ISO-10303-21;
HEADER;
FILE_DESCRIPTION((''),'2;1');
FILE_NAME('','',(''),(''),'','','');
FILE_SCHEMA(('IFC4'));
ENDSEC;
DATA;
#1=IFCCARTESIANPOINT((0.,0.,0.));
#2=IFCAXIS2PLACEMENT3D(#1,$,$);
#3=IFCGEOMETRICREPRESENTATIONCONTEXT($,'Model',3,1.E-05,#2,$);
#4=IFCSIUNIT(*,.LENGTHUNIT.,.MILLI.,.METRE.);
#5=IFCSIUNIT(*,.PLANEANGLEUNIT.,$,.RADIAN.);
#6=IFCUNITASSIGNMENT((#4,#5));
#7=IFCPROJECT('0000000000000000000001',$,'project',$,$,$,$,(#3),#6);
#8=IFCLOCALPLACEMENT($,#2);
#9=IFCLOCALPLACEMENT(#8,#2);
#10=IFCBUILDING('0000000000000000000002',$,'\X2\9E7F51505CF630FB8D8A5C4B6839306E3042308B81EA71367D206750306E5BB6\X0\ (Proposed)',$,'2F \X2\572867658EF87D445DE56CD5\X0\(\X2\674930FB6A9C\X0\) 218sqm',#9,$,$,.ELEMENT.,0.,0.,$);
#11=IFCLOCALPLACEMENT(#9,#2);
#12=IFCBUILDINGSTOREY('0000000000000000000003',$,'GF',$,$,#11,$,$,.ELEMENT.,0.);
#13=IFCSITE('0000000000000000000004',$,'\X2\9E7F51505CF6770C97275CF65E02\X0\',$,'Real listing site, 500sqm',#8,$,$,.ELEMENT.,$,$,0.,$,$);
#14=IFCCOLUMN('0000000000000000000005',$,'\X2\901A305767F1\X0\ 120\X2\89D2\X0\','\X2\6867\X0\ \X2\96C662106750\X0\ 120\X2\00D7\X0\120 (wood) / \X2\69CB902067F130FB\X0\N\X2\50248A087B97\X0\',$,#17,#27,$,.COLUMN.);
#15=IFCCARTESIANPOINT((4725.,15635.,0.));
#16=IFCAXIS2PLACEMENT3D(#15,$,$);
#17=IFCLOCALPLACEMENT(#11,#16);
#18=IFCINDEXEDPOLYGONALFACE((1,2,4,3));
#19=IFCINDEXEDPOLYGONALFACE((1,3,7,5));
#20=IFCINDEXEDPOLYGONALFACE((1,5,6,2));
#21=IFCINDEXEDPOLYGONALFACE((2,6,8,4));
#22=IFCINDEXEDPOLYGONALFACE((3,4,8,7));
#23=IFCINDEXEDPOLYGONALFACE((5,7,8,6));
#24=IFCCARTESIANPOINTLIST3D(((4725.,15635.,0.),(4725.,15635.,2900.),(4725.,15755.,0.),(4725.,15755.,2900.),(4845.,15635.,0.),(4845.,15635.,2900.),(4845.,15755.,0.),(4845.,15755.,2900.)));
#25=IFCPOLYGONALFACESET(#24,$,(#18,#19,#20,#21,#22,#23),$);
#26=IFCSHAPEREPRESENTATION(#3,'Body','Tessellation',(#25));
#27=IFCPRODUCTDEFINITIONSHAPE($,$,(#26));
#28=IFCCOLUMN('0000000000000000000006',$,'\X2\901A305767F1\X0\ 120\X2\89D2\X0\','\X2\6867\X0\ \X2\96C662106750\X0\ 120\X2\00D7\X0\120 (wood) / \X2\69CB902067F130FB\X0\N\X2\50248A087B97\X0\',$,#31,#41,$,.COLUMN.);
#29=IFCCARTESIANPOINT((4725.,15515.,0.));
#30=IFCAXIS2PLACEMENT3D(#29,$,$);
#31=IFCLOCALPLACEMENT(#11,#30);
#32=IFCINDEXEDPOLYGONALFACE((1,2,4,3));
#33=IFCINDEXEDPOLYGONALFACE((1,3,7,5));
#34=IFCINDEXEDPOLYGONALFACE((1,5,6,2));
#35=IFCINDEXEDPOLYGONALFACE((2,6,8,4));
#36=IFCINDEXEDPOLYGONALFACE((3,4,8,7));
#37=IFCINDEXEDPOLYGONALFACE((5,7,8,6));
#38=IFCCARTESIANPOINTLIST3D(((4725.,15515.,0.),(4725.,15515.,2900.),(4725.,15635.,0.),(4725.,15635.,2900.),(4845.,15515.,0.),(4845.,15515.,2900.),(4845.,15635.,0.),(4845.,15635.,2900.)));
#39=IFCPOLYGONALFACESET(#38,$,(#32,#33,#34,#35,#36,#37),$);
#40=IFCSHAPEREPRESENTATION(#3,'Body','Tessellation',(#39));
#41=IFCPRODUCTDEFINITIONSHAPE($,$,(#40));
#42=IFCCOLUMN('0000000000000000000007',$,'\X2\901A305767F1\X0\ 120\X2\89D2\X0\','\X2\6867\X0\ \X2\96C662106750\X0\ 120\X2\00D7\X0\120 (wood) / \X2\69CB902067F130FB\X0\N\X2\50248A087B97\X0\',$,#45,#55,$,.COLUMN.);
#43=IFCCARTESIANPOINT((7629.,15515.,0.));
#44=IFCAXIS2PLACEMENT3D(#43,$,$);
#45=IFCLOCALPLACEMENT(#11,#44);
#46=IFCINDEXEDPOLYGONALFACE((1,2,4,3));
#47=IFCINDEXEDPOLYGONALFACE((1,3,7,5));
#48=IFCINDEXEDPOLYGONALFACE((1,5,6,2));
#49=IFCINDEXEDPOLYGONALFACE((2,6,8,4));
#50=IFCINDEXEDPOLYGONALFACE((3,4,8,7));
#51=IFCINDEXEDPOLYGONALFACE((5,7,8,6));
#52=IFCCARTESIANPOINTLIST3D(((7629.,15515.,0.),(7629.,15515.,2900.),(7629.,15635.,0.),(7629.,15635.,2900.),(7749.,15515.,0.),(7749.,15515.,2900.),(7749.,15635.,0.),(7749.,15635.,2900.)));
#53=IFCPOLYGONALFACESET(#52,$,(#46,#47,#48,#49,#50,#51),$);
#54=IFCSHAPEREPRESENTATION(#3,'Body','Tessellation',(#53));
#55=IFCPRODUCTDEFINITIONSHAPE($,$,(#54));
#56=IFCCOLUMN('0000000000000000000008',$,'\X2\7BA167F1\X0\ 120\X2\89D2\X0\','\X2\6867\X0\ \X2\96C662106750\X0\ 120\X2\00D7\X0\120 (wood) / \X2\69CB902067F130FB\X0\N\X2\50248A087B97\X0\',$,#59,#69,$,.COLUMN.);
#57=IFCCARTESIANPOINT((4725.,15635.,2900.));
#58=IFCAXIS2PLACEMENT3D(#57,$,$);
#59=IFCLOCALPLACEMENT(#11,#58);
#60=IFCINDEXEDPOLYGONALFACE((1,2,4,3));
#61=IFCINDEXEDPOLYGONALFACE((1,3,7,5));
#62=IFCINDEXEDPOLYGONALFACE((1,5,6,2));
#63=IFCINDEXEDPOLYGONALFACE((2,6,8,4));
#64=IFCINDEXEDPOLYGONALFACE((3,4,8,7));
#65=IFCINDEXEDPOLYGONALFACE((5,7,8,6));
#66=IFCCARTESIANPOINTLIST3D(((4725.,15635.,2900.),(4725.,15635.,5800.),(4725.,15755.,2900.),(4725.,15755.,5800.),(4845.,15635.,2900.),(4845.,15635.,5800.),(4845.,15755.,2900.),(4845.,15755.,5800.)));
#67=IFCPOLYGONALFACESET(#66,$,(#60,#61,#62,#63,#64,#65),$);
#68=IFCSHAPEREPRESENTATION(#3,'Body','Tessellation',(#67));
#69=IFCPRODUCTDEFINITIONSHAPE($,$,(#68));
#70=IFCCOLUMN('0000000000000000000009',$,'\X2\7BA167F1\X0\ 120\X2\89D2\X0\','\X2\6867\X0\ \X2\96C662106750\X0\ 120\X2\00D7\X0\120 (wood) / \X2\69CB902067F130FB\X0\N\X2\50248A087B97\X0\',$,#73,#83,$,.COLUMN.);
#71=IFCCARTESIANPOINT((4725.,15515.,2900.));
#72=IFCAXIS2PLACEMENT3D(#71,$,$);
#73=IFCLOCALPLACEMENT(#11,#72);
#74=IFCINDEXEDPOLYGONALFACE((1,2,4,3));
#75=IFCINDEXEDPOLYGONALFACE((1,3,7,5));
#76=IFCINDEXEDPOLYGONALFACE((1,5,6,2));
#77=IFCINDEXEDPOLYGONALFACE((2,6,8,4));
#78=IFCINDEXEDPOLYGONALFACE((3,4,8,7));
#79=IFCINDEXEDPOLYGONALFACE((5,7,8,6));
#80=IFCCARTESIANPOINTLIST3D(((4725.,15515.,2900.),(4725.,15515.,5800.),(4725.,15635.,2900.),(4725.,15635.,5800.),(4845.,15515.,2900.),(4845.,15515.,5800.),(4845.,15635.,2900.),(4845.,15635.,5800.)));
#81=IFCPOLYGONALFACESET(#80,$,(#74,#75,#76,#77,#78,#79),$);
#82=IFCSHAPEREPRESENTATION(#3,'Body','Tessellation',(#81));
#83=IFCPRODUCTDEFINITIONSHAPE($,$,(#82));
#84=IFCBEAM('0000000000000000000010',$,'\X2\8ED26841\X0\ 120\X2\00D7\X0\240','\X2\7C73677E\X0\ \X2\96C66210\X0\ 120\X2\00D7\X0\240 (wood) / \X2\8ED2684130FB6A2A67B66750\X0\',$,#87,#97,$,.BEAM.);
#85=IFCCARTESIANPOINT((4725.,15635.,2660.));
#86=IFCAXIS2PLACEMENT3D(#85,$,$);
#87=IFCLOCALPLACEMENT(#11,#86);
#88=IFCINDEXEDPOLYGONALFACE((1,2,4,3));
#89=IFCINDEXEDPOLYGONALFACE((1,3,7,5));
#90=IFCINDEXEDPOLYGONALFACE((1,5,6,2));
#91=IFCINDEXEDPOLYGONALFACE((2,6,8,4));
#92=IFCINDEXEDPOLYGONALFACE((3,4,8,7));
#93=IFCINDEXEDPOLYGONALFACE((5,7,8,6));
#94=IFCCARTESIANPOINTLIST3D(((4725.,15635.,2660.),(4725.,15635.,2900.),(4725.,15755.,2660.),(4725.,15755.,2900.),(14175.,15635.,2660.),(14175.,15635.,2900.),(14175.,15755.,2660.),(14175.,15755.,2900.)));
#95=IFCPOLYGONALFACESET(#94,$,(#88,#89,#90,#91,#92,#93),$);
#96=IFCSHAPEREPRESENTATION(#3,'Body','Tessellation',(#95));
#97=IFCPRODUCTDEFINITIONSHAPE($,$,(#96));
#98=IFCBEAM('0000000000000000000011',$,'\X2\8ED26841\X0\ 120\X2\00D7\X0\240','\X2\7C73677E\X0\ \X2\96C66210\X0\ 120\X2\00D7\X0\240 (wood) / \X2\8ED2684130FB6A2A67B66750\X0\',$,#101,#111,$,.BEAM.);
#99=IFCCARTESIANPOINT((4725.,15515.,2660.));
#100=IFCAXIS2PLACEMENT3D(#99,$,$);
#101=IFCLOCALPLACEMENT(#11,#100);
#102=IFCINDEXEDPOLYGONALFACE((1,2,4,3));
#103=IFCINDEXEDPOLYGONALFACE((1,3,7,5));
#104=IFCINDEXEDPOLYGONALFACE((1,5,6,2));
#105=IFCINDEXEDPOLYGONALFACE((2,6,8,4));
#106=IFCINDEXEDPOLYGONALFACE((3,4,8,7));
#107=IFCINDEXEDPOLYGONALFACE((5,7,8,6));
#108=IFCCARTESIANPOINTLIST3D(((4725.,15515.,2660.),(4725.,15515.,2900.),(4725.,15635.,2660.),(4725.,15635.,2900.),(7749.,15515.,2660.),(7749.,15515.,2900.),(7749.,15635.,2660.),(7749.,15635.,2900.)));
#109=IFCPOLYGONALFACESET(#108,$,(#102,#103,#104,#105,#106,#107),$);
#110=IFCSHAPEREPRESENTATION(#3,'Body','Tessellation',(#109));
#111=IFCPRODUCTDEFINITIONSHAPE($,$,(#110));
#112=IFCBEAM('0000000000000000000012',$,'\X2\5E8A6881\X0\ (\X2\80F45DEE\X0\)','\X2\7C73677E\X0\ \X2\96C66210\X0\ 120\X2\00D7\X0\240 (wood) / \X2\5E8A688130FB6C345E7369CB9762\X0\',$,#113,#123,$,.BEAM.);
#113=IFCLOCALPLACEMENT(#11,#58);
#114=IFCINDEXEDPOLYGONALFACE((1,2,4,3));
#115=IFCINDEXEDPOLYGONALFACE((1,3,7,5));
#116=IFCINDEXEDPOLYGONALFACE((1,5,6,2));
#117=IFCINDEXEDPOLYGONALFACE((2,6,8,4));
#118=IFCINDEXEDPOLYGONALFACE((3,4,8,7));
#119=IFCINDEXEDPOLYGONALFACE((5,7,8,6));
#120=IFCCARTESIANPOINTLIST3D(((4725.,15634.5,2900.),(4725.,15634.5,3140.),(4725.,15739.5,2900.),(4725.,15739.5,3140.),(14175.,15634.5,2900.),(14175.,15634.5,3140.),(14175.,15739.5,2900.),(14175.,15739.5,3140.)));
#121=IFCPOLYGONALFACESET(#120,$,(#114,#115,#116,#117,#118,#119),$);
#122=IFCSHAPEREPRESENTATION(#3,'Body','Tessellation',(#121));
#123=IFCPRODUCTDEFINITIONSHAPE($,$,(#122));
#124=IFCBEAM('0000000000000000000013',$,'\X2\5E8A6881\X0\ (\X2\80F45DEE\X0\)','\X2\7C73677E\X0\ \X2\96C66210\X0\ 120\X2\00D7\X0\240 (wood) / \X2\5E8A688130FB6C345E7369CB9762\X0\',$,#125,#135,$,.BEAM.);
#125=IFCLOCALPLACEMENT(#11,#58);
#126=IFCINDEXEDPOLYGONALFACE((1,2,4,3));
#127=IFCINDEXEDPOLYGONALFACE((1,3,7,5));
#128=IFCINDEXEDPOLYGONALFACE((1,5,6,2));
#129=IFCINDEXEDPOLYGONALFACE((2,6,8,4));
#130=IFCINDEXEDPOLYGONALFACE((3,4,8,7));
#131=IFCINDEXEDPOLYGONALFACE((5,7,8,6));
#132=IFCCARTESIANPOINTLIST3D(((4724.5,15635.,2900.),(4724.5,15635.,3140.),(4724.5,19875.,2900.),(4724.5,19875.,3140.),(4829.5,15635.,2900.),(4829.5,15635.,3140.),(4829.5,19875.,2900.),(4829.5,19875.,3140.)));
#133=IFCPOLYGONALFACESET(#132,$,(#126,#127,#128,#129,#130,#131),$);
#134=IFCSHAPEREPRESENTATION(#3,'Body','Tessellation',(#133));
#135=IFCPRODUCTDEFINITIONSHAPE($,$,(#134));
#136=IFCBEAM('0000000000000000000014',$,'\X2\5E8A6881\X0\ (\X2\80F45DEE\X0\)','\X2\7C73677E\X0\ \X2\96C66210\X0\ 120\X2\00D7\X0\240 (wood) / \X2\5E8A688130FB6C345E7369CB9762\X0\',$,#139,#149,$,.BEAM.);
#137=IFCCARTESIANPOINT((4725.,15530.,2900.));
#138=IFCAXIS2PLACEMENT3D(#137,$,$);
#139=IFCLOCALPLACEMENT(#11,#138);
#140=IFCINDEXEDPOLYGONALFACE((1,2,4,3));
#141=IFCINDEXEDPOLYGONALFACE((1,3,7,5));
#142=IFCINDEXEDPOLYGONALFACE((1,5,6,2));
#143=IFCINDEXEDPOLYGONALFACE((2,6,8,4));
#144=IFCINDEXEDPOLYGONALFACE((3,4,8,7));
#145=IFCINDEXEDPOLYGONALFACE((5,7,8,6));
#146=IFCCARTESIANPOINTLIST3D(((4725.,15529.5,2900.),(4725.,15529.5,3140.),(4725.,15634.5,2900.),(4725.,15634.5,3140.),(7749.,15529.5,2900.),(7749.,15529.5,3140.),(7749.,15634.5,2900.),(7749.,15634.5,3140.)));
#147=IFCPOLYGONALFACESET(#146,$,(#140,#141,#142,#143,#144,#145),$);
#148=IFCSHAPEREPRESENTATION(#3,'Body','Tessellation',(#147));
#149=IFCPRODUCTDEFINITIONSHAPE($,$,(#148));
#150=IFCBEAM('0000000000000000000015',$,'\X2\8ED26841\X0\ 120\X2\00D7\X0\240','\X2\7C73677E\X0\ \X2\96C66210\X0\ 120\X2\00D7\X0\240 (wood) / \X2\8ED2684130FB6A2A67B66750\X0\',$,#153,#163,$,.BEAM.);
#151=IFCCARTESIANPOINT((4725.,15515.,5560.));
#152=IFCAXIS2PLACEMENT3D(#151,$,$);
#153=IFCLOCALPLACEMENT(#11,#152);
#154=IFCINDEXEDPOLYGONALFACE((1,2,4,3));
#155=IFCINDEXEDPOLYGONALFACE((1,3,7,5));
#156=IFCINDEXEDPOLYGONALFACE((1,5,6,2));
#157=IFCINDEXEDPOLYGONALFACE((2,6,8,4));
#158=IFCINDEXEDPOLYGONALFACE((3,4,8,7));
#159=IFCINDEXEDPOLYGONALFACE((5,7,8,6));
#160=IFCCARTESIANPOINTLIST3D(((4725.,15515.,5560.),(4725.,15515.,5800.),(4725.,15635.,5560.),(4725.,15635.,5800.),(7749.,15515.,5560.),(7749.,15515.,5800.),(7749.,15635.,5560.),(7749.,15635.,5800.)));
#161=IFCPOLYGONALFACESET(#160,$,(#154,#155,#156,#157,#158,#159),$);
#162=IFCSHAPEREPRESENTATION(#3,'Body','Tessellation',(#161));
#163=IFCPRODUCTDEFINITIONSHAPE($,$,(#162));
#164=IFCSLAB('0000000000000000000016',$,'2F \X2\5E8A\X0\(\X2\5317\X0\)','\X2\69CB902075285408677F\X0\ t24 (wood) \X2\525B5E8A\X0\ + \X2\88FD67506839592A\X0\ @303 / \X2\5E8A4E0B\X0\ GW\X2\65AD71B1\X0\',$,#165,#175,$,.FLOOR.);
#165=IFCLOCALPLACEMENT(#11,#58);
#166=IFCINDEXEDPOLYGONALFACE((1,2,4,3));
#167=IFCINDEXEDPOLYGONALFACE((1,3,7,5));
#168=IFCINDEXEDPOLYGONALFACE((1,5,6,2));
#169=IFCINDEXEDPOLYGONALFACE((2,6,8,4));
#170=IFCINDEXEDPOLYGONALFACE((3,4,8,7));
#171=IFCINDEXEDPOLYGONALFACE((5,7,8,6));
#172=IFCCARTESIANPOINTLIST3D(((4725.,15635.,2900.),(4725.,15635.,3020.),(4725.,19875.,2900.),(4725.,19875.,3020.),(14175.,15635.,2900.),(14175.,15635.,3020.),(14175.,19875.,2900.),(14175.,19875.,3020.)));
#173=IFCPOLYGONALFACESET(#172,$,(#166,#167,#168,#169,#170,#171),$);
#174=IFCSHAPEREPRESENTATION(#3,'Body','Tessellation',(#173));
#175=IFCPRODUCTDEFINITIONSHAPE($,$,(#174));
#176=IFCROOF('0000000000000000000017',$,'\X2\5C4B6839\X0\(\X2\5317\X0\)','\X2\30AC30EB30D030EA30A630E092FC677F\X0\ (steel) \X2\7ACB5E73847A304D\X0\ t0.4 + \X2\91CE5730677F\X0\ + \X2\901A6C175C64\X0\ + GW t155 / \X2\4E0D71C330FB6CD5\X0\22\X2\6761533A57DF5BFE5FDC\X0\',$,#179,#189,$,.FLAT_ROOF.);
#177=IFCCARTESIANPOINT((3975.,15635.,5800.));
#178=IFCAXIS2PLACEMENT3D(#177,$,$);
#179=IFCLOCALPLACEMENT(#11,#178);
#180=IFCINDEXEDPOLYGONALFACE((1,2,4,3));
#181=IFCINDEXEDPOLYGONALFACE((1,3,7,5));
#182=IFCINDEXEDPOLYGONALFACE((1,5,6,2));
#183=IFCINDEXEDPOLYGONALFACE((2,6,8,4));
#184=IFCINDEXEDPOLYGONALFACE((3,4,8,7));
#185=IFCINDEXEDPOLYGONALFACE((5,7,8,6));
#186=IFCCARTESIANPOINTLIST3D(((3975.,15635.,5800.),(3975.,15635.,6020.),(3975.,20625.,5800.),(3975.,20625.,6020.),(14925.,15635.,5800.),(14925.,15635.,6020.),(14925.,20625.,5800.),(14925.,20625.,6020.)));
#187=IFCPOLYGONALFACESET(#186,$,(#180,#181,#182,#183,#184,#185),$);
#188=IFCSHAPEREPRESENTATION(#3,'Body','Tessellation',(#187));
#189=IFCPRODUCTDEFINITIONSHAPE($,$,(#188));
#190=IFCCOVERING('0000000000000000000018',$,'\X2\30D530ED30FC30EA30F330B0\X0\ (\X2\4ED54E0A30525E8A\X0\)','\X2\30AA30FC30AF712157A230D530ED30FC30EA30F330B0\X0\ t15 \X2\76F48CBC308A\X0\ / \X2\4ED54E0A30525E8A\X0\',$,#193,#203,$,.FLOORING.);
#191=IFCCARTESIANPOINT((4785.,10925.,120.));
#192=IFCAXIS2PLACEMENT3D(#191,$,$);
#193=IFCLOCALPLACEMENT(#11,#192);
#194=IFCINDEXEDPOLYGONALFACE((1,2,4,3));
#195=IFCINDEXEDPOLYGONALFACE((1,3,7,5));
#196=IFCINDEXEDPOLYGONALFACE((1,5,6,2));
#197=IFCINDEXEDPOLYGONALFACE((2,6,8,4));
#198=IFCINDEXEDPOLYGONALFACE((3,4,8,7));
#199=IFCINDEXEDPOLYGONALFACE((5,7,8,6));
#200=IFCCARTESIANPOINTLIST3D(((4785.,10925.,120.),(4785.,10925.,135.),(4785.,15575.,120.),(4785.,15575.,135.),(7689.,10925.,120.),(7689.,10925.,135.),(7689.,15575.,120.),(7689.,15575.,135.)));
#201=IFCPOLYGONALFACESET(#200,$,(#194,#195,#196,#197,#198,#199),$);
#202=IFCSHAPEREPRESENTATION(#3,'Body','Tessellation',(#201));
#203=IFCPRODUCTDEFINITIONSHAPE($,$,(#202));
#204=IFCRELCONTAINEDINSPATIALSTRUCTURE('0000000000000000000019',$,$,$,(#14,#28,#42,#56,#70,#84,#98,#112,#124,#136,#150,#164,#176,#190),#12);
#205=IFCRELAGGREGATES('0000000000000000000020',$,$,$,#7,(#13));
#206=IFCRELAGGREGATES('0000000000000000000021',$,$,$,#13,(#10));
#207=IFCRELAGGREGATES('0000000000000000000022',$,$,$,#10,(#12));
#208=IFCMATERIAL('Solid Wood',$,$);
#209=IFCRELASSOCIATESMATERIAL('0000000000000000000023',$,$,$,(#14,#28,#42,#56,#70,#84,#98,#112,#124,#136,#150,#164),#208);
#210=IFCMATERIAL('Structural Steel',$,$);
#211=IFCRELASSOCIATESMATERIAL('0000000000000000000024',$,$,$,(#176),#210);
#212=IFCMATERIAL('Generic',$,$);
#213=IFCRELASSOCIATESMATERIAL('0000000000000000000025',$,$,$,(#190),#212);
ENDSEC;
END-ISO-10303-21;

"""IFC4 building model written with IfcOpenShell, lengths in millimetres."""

from ifc_helpers import new_model, si_unit, frame, frame_2d, origin, place, context, project, spatial, rectangle, extrude, material, element, save


model = new_model("IFC4")

# Units and contexts
model_context = context("Model", 3, precision=1e-05, world=origin())
ifc_project = project(units=[si_unit("LENGTHUNIT", "METRE", prefix="MILLI"), si_unit("PLANEANGLEUNIT", "RADIAN")], contexts=[model_context])

# Site, building, storey
site_placement = place(None, origin())
site = spatial("IfcSite", under=ifc_project, at=site_placement, Name="鹿児島県霧島市", ObjectType="Real listing site, 500sqm", CompositionType="ELEMENT", RefElevation=0.0)
building_placement = place(site_placement, origin())
building = spatial("IfcBuilding", under=site, at=building_placement, Name="鹿児島・越屋根のある自然素材の家 (Proposed)", ObjectType="2F 在来軸組工法(杉・檜) 218sqm", CompositionType="ELEMENT", ElevationOfRefHeight=0.0, ElevationOfTerrain=0.0)
storey_placement = place(building_placement, origin())
storey = spatial("IfcBuildingStorey", under=building, at=storey_placement, Name="GF", CompositionType="ELEMENT", Elevation=0.0)

# Columns
ifc_material_1 = material(Name="Solid Wood")
column_1_placement = place(storey_placement, frame((4725.0, 15635.0, 0.0)))
element("IfcColumn", 1, at=column_1_placement, inside=storey, material=ifc_material_1, Name="通し柱 120角", Description="桧 集成材 120×120 (wood) / 構造柱・N値計算", PredefinedType="COLUMN", context=model_context, shape_type="SweptSolid", body=[
    extrude(rectangle(XDim=120.0, YDim=120.0, at=frame_2d((60.0, 60.0))), frame((4725.0, 15635.0, 0.0)), (0.0, 0.0, 1.0), 2900.0),
])
column_2_placement = place(storey_placement, frame((4725.0, 15515.0, 0.0)))
element("IfcColumn", 2, at=column_2_placement, inside=storey, material=ifc_material_1, Name="通し柱 120角", Description="桧 集成材 120×120 (wood) / 構造柱・N値計算", PredefinedType="COLUMN", context=model_context, shape_type="SweptSolid", body=[
    extrude(rectangle(XDim=120.0, YDim=120.0, at=frame_2d((60.0, 60.0))), frame((4725.0, 15515.0, 0.0)), (0.0, 0.0, 1.0), 2900.0),
])
column_3_placement = place(storey_placement, frame((7629.0, 15515.0, 0.0)))
element("IfcColumn", 3, at=column_3_placement, inside=storey, material=ifc_material_1, Name="通し柱 120角", Description="桧 集成材 120×120 (wood) / 構造柱・N値計算", PredefinedType="COLUMN", context=model_context, shape_type="SweptSolid", body=[
    extrude(rectangle(XDim=120.0, YDim=120.0, at=frame_2d((60.0, 60.0))), frame((7629.0, 15515.0, 0.0)), (0.0, 0.0, 1.0), 2900.0),
])
column_4_placement = place(storey_placement, frame((4725.0, 15635.0, 2900.0)))
element("IfcColumn", 4, at=column_4_placement, inside=storey, material=ifc_material_1, Name="管柱 120角", Description="桧 集成材 120×120 (wood) / 構造柱・N値計算", PredefinedType="COLUMN", context=model_context, shape_type="SweptSolid", body=[
    extrude(rectangle(XDim=120.0, YDim=120.0, at=frame_2d((60.0, 60.0))), frame((4725.0, 15635.0, 2900.0)), (0.0, 0.0, 1.0), 2900.0),
])
column_5_placement = place(storey_placement, frame((4725.0, 15515.0, 2900.0)))
element("IfcColumn", 5, at=column_5_placement, inside=storey, material=ifc_material_1, Name="管柱 120角", Description="桧 集成材 120×120 (wood) / 構造柱・N値計算", PredefinedType="COLUMN", context=model_context, shape_type="SweptSolid", body=[
    extrude(rectangle(XDim=120.0, YDim=120.0, at=frame_2d((60.0, 60.0))), frame((4725.0, 15515.0, 2900.0)), (0.0, 0.0, 1.0), 2900.0),
])

# Beams
beam_1_placement = place(storey_placement, frame((4725.0, 15635.0, 2660.0)))
element("IfcBeam", 6, at=beam_1_placement, inside=storey, material=ifc_material_1, Name="軒桁 120×240", Description="米松 集成 120×240 (wood) / 軒桁・横架材", PredefinedType="BEAM", context=model_context, shape_type="SweptSolid", body=[
    extrude(rectangle(XDim=9450.0, YDim=120.0, at=frame_2d((4725.0, 60.0))), frame((4725.0, 15635.0, 2660.0)), (0.0, 0.0, 1.0), 240.0),
])
beam_2_placement = place(storey_placement, frame((4725.0, 15515.0, 2660.0)))
element("IfcBeam", 7, at=beam_2_placement, inside=storey, material=ifc_material_1, Name="軒桁 120×240", Description="米松 集成 120×240 (wood) / 軒桁・横架材", PredefinedType="BEAM", context=model_context, shape_type="SweptSolid", body=[
    extrude(rectangle(XDim=3024.0, YDim=120.0, at=frame_2d((1512.0, 60.0))), frame((4725.0, 15515.0, 2660.0)), (0.0, 0.0, 1.0), 240.0),
])
beam_3_placement = place(storey_placement, frame((4725.0, 15635.0, 2900.0)))
element("IfcBeam", 8, at=beam_3_placement, inside=storey, material=ifc_material_1, Name="床梁 (胴差)", Description="米松 集成 120×240 (wood) / 床梁・水平構面", PredefinedType="BEAM", context=model_context, shape_type="SweptSolid", body=[
    extrude(rectangle(XDim=9450.0, YDim=105.0, at=frame_2d((4725.0, 52.0))), frame((4725.0, 15635.0, 2900.0)), (0.0, 0.0, 1.0), 240.0),
])
beam_4_placement = place(storey_placement, frame((4725.0, 15635.0, 2900.0)))
element("IfcBeam", 9, at=beam_4_placement, inside=storey, material=ifc_material_1, Name="床梁 (胴差)", Description="米松 集成 120×240 (wood) / 床梁・水平構面", PredefinedType="BEAM", context=model_context, shape_type="SweptSolid", body=[
    extrude(rectangle(XDim=105.0, YDim=4240.0, at=frame_2d((52.0, 2120.0))), frame((4725.0, 15635.0, 2900.0)), (0.0, 0.0, 1.0), 240.0),
])
beam_5_placement = place(storey_placement, frame((4725.0, 15530.0, 2900.0)))
element("IfcBeam", 10, at=beam_5_placement, inside=storey, material=ifc_material_1, Name="床梁 (胴差)", Description="米松 集成 120×240 (wood) / 床梁・水平構面", PredefinedType="BEAM", context=model_context, shape_type="SweptSolid", body=[
    extrude(rectangle(XDim=3024.0, YDim=105.0, at=frame_2d((1512.0, 52.0))), frame((4725.0, 15530.0, 2900.0)), (0.0, 0.0, 1.0), 240.0),
])
beam_6_placement = place(storey_placement, frame((4725.0, 15515.0, 5560.0)))
element("IfcBeam", 11, at=beam_6_placement, inside=storey, material=ifc_material_1, Name="軒桁 120×240", Description="米松 集成 120×240 (wood) / 軒桁・横架材", PredefinedType="BEAM", context=model_context, shape_type="SweptSolid", body=[
    extrude(rectangle(XDim=3024.0, YDim=120.0, at=frame_2d((1512.0, 60.0))), frame((4725.0, 15515.0, 5560.0)), (0.0, 0.0, 1.0), 240.0),
])

# Slab
slab_1_placement = place(storey_placement, frame((4725.0, 15635.0, 2900.0)))
element("IfcSlab", 12, at=slab_1_placement, inside=storey, material=ifc_material_1, Name="2F 床(北)", Description="構造用合板 t24 (wood) 剛床 + 製材根太 @303 / 床下 GW断熱", PredefinedType="FLOOR", context=model_context, shape_type="SweptSolid", body=[
    extrude(rectangle(XDim=9450.0, YDim=4240.0, at=frame_2d((4725.0, 2120.0))), frame((4725.0, 15635.0, 2900.0)), (0.0, 0.0, 1.0), 120.0),
])

# Roof
ifc_material_2 = material(Name="Structural Steel")
for number, where, name in (
    (13, (3975.0, 15635.0, 5800.0), "屋根(北)"),
):
    element("IfcRoof", number, at=place(storey_placement, frame(where)), inside=storey, material=ifc_material_2, Name=name, Description="ガルバリウム鋼板 (steel) 立平葺き t0.4 + 野地板 + 通気層 + GW t155 / 不燃・法22条区域対応", PredefinedType="FLAT_ROOF", context=model_context, shape_type="SweptSolid", body=[
        extrude(rectangle(XDim=10950.0, YDim=4990.0, at=frame_2d((5475.0, 2495.0))), frame((3975.0, 15635.0, 5800.0)), (0.0, 0.0, 1.0), 220.0),
    ])

# Covering
ifc_material_3 = material(Name="Generic")
covering_1_placement = place(storey_placement, frame((4785.0, 10925.0, 120.0)))
element("IfcCovering", 14, at=covering_1_placement, inside=storey, material=ifc_material_3, Name="フローリング (仕上げ床)", Description="オーク無垢フローリング t15 直貼り / 仕上げ床", PredefinedType="FLOORING", context=model_context, shape_type="SweptSolid", body=[
    extrude(rectangle(XDim=2904.0, YDim=4650.0, at=frame_2d((1452.0, 2325.0))), frame((4785.0, 10925.0, 120.0)), (0.0, 0.0, 1.0), 15.0),
])

save(model, "model.ifc")
